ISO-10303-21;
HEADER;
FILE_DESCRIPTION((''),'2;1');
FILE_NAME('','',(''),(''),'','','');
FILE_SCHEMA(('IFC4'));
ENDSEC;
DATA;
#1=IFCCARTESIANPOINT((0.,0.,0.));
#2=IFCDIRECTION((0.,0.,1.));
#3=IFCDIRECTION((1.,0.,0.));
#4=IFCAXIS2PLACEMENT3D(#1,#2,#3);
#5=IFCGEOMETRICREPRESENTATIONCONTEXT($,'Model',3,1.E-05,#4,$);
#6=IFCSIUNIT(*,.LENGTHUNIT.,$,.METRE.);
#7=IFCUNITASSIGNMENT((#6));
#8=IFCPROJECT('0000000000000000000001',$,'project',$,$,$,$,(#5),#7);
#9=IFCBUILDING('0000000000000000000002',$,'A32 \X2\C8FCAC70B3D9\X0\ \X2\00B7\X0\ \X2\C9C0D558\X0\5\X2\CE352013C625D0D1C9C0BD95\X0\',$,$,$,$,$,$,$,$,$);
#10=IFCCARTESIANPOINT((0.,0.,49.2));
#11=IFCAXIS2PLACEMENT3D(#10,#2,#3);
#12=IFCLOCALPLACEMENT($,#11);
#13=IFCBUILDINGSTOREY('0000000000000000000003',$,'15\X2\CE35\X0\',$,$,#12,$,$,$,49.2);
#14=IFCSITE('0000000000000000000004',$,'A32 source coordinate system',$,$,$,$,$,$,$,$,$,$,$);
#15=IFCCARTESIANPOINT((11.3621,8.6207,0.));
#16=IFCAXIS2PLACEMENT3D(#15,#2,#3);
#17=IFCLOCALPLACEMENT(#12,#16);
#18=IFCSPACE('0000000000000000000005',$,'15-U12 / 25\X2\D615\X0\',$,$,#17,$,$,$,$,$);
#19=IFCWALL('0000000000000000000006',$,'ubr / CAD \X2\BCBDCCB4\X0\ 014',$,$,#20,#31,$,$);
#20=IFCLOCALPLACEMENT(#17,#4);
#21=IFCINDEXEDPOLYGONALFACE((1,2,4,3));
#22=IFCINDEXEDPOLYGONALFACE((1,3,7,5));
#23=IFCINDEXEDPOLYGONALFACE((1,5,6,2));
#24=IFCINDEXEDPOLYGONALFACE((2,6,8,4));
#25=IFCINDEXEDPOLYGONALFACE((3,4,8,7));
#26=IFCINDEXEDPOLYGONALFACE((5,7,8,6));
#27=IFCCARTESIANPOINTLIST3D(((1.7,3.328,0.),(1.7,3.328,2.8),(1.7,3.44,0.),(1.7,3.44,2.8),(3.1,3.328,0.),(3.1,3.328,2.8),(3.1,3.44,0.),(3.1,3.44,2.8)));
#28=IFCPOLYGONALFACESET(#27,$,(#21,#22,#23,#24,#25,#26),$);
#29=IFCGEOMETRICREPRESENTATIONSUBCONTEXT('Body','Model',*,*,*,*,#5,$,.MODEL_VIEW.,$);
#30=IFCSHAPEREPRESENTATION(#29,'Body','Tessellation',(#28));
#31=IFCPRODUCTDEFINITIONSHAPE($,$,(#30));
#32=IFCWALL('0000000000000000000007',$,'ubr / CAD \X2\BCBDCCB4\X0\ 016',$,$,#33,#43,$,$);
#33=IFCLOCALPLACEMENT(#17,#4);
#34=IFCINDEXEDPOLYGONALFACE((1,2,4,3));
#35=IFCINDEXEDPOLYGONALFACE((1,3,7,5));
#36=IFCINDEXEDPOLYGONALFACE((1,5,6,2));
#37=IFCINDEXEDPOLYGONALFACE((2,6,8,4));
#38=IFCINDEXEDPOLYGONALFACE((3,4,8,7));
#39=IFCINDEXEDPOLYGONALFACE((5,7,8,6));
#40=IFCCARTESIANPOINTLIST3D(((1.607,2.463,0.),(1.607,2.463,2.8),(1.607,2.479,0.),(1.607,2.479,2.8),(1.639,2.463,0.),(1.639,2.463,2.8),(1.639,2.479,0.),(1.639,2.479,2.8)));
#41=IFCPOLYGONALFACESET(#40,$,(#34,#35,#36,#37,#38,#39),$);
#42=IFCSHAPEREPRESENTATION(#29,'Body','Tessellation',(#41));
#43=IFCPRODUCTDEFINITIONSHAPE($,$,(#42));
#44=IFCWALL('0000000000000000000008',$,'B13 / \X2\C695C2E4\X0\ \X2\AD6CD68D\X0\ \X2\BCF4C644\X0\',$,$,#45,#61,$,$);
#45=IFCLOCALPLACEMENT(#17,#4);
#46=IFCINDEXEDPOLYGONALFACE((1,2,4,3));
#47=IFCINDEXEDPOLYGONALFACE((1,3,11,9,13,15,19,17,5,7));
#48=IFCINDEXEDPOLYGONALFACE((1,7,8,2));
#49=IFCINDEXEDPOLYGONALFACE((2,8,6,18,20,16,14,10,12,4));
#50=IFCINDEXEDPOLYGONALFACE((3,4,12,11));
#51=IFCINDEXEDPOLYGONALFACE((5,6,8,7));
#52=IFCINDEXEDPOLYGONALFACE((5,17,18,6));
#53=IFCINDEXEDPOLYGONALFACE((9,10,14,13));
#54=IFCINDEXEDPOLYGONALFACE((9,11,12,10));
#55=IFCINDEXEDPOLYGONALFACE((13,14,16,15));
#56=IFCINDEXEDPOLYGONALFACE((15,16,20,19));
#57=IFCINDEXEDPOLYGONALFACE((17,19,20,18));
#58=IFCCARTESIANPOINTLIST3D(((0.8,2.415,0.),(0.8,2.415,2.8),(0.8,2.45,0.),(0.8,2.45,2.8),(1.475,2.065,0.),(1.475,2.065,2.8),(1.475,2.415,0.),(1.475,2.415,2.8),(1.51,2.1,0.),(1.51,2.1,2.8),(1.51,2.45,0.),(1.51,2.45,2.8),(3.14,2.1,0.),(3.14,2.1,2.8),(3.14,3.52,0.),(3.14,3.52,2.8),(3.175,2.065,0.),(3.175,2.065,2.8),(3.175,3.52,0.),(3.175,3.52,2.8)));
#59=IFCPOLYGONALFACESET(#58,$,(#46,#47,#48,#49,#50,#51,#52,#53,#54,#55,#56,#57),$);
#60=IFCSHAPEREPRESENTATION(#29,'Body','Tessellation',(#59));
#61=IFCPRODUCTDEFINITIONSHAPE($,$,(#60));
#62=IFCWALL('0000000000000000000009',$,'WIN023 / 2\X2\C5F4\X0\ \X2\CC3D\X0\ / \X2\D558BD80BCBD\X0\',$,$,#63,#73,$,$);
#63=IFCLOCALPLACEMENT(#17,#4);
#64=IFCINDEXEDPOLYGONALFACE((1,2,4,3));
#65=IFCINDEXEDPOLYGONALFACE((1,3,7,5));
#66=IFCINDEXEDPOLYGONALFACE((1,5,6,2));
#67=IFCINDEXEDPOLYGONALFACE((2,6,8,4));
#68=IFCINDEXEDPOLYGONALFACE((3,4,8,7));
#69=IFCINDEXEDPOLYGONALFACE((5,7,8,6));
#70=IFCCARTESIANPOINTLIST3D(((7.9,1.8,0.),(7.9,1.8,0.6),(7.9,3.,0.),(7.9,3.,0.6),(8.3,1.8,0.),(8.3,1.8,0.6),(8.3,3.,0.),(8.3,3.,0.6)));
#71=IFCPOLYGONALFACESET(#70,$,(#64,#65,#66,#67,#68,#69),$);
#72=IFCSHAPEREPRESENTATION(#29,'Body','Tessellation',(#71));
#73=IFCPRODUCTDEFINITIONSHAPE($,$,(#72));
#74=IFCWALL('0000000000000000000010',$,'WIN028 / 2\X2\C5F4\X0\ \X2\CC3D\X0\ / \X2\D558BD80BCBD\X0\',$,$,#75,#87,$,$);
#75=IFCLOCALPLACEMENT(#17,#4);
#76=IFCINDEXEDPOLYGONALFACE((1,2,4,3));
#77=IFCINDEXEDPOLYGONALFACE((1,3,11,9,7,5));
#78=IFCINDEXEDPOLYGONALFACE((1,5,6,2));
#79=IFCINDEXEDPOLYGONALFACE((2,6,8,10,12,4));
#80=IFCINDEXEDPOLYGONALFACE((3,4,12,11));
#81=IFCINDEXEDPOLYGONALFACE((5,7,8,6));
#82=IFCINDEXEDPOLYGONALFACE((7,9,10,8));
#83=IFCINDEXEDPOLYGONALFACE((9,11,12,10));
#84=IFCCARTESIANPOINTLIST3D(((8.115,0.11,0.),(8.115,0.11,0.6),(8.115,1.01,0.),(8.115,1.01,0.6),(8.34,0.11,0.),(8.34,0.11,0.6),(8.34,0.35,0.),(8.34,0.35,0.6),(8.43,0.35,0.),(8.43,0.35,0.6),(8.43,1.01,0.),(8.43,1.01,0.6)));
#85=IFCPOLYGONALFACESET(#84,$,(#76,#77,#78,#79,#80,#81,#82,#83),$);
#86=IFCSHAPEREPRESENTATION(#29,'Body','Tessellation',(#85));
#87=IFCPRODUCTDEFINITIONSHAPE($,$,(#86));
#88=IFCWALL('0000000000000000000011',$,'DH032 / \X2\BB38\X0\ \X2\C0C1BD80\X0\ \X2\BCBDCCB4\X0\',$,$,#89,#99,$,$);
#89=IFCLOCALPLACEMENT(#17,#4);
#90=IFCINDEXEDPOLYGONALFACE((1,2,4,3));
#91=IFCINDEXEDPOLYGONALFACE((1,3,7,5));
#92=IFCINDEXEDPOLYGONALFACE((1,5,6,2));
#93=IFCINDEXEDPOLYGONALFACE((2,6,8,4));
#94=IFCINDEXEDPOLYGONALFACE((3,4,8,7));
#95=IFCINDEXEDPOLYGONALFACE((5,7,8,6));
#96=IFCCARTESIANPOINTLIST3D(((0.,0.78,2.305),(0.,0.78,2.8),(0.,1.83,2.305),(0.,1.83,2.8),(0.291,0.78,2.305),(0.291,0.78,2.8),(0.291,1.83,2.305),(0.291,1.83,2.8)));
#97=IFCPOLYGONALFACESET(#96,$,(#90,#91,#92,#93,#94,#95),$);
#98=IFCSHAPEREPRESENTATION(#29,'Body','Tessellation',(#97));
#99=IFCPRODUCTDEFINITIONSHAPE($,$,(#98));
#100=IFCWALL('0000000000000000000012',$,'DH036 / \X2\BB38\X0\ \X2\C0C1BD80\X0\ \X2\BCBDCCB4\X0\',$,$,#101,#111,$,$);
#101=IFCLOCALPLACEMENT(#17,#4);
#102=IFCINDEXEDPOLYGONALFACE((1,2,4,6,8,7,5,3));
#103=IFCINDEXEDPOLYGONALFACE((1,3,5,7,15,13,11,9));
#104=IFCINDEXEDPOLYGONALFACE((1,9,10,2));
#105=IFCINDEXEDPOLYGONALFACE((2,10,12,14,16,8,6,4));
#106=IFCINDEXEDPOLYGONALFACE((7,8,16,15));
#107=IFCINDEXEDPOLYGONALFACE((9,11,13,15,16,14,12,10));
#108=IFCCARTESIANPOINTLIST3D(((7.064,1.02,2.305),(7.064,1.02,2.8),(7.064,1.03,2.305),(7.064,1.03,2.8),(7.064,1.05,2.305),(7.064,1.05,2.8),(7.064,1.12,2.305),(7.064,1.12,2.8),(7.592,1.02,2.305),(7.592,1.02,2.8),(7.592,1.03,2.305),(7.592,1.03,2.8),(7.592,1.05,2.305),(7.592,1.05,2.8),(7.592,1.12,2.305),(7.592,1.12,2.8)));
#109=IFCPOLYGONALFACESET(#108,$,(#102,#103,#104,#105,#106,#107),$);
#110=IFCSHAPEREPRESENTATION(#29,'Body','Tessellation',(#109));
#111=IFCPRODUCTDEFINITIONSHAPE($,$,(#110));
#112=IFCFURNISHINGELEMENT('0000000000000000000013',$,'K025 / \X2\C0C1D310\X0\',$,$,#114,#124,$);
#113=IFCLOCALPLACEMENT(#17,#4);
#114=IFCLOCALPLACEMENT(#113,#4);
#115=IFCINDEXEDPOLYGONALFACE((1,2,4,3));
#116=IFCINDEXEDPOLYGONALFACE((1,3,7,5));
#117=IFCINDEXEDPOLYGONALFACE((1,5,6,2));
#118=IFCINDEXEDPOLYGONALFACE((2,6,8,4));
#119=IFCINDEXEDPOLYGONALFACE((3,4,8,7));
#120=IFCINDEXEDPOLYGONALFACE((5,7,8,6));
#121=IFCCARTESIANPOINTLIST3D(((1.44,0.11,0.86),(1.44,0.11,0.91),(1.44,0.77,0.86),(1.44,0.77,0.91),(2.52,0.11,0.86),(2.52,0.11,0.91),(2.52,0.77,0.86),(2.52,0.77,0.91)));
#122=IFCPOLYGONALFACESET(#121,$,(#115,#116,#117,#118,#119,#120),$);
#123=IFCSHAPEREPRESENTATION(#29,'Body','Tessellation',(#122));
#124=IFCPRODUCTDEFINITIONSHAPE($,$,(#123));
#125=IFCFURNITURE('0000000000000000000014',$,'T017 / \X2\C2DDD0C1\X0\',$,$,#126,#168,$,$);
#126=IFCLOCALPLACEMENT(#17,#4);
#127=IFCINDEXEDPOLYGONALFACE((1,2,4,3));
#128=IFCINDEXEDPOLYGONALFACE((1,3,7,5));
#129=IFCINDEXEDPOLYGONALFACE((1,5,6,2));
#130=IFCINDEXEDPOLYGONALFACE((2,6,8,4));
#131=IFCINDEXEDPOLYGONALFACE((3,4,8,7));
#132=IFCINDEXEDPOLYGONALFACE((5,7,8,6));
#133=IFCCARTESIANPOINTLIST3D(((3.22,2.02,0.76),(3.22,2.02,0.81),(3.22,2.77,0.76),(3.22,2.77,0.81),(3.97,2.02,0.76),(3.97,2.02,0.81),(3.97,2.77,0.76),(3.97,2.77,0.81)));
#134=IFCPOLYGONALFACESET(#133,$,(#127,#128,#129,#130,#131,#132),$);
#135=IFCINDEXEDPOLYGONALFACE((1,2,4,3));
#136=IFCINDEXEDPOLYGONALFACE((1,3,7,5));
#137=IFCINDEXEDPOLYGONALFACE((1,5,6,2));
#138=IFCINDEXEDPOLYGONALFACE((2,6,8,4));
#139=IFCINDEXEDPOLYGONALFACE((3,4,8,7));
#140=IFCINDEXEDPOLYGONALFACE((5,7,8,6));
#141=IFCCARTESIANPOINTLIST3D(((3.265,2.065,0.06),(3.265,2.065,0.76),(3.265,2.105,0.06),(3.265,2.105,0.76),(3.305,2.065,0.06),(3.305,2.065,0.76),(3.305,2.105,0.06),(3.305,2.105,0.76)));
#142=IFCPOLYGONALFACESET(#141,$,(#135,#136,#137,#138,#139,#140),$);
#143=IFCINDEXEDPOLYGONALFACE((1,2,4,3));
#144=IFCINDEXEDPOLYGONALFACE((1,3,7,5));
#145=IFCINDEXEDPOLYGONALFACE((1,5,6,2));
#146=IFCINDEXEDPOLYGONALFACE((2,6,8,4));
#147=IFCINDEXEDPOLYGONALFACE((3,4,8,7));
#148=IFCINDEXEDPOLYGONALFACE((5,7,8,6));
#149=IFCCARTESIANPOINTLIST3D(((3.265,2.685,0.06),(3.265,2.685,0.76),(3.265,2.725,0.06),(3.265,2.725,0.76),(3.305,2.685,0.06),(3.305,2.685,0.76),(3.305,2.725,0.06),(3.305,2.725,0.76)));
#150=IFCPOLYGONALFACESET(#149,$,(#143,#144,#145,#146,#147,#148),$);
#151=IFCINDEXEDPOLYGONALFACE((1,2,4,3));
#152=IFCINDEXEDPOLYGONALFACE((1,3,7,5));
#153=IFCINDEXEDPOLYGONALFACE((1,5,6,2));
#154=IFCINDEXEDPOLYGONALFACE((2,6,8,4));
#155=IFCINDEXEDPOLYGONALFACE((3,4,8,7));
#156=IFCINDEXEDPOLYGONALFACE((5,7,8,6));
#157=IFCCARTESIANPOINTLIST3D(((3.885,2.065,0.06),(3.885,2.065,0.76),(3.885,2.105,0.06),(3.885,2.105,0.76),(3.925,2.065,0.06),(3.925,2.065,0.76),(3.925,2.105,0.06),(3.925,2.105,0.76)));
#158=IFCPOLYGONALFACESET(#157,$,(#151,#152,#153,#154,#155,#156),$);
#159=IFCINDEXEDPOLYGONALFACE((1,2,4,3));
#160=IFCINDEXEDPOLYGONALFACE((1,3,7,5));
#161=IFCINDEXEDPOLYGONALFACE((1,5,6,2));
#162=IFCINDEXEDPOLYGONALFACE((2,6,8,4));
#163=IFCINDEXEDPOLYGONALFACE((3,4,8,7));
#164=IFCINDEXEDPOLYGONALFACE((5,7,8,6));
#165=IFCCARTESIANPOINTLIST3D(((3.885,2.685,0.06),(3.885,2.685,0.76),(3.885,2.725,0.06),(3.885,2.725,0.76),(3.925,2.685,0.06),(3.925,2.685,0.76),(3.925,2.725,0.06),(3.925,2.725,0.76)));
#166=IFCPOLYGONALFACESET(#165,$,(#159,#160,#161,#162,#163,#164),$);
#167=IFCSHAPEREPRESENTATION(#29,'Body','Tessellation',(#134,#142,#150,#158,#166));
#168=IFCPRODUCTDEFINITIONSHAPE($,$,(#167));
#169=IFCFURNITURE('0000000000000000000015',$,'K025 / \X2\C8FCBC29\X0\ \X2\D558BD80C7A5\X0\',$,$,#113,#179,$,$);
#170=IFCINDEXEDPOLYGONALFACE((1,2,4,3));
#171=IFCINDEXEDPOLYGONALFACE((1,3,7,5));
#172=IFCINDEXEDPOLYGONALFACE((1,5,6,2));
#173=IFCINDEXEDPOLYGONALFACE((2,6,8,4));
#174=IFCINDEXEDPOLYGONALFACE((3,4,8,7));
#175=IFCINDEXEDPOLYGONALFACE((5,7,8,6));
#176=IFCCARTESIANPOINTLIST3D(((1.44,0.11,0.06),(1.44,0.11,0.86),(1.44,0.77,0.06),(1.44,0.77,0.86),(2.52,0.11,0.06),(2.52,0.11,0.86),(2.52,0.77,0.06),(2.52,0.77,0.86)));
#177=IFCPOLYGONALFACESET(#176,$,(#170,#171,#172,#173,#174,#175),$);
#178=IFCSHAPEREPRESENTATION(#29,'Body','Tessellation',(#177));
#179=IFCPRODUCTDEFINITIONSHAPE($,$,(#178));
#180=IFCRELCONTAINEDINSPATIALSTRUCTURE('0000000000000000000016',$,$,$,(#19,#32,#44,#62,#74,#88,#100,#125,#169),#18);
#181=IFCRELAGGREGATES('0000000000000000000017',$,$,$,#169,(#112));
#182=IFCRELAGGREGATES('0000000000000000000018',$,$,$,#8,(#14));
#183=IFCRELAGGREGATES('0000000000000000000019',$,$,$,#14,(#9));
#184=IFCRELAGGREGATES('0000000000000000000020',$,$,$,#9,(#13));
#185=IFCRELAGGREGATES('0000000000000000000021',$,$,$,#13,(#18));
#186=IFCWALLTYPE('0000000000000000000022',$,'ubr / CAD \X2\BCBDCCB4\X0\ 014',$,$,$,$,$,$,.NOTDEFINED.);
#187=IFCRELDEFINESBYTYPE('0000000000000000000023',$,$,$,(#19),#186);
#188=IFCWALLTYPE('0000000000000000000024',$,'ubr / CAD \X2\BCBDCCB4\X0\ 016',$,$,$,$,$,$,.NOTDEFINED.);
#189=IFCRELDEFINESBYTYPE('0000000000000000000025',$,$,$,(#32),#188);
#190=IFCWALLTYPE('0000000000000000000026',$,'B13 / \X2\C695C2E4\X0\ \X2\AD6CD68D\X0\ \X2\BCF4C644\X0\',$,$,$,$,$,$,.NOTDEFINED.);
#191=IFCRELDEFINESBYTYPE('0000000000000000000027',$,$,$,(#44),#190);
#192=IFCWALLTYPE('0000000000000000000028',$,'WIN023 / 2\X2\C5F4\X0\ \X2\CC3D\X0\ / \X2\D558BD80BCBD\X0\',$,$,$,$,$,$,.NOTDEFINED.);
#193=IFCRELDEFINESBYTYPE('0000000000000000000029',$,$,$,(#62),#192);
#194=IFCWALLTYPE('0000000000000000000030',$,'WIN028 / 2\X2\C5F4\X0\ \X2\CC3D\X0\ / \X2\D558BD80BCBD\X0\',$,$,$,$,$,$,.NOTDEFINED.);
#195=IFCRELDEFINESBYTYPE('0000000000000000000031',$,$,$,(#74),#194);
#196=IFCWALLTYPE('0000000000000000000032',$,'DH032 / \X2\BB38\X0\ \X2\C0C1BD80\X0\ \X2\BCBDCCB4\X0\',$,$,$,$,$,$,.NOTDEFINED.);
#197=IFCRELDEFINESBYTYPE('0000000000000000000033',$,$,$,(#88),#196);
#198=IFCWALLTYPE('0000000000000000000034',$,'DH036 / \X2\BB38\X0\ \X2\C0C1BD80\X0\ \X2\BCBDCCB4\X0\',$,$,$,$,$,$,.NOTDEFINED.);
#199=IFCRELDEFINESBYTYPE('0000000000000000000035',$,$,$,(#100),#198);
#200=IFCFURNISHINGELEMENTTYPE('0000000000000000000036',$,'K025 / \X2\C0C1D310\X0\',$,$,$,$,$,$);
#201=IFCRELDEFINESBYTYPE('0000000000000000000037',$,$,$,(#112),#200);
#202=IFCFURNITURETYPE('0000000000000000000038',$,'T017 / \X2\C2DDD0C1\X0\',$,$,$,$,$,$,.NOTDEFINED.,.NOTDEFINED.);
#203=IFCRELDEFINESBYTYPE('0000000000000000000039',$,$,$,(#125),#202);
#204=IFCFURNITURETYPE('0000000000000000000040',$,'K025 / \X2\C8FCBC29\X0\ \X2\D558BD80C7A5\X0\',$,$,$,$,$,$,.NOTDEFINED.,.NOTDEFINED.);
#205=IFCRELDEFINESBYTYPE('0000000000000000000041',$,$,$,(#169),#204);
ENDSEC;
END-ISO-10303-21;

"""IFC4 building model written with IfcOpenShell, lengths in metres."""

from ifc_helpers import new_model, si_unit, frame, origin, origin_with_axes, place, context, subcontext, project, spatial, polyline, outline, extrude, source, transform, mapped, type_object, type_shapes, element, aggregate, save


model = new_model("IFC4")

# Units and contexts
model_context = context("Model", 3, precision=1e-05, world=origin_with_axes())
body_context = subcontext(model_context, "Body", "Model", "MODEL_VIEW")
ifc_project = project(units=[si_unit("LENGTHUNIT", "METRE")], contexts=[model_context])

# Site, building, storey, space
site = spatial("IfcSite", under=ifc_project, Name="A32 source coordinate system")
building = spatial("IfcBuilding", under=site, Name="A32 주거동 · 지하5층–옥탑지붕")
storey_placement = place(None, frame((0.0, 0.0, 49.2), z_axis=(0.0, 0.0, 1.0), x_axis=(1.0, 0.0, 0.0)))
storey = spatial("IfcBuildingStorey", under=building, at=storey_placement, Name="15층", Elevation=49.2)
space_1_placement = place(storey_placement, frame((11.3621, 8.6207, 0.0), z_axis=(0.0, 0.0, 1.0), x_axis=(1.0, 0.0, 0.0)))
space_1 = spatial("IfcSpace", under=storey, at=space_1_placement, Name="15-U12 / 25형")

# Walls
wall_type_1 = type_object("IfcWallType", Name="ubr / CAD 벽체 014", PredefinedType="NOTDEFINED")
shared_shape_1 = source(origin(), body_context, "Body", "SweptSolid", [
    extrude(outline(polyline([(3.1, 3.44), (3.1, 3.328), (1.7, 3.328), (1.7, 3.44), (3.1, 3.44)])), origin(), (0.0, 0.0, 1.0), 2.8),
])
type_shapes(wall_type_1, [shared_shape_1])
wall_1_placement = place(space_1_placement, origin_with_axes())
element("IfcWall", 1, at=wall_1_placement, inside=space_1, type_object=wall_type_1, Name="ubr / CAD 벽체 014", context=body_context, shape_type="MappedRepresentation", body=[
    mapped(shared_shape_1, transform((0.0, 0.0, 0.0), scale=1.0)),
])
wall_type_2 = type_object("IfcWallType", Name="ubr / CAD 벽체 016", PredefinedType="NOTDEFINED")
shared_shape_2 = source(origin(), body_context, "Body", "SweptSolid", [
    extrude(outline(polyline([(1.639, 2.479), (1.639, 2.463), (1.607, 2.463), (1.607, 2.479), (1.639, 2.479)])), origin(), (0.0, 0.0, 1.0), 2.8),
])
type_shapes(wall_type_2, [shared_shape_2])
wall_2_placement = place(space_1_placement, origin_with_axes())
element("IfcWall", 2, at=wall_2_placement, inside=space_1, type_object=wall_type_2, Name="ubr / CAD 벽체 016", context=body_context, shape_type="MappedRepresentation", body=[
    mapped(shared_shape_2, transform((0.0, 0.0, 0.0), scale=1.0)),
])
wall_type_3 = type_object("IfcWallType", Name="B13 / 욕실 구획 보완", PredefinedType="NOTDEFINED")
shared_shape_3 = source(origin(), body_context, "Body", "SweptSolid", [
    extrude(outline(polyline([(0.8, 2.45), (1.51, 2.45), (1.51, 2.1), (3.14, 2.1), (3.14, 3.52), (3.175, 3.52), (3.175, 2.065), (1.475, 2.065), (1.475, 2.415), (0.8, 2.415), (0.8, 2.45)])), origin(), (0.0, 0.0, 1.0), 2.8),
])
type_shapes(wall_type_3, [shared_shape_3])
wall_3_placement = place(space_1_placement, origin_with_axes())
element("IfcWall", 3, at=wall_3_placement, inside=space_1, type_object=wall_type_3, Name="B13 / 욕실 구획 보완", context=body_context, shape_type="MappedRepresentation", body=[
    mapped(shared_shape_3, transform((0.0, 0.0, 0.0), scale=1.0)),
])
wall_type_4 = type_object("IfcWallType", Name="WIN023 / 2열 창 / 하부벽", PredefinedType="NOTDEFINED")
shared_shape_4 = source(origin(), body_context, "Body", "SweptSolid", [
    extrude(outline(polyline([(7.9, 1.8), (7.9, 3.0), (8.3, 3.0), (8.3, 1.8), (7.9, 1.8)])), origin(), (0.0, 0.0, 1.0), 0.6),
])
type_shapes(wall_type_4, [shared_shape_4])
wall_4_placement = place(space_1_placement, origin_with_axes())
element("IfcWall", 4, at=wall_4_placement, inside=space_1, type_object=wall_type_4, Name="WIN023 / 2열 창 / 하부벽", context=body_context, shape_type="MappedRepresentation", body=[
    mapped(shared_shape_4, transform((0.0, 0.0, 0.0), scale=1.0)),
])
wall_type_5 = type_object("IfcWallType", Name="WIN028 / 2열 창 / 하부벽", PredefinedType="NOTDEFINED")
shared_shape_5 = source(origin(), body_context, "Body", "SweptSolid", [
    extrude(outline(polyline([(8.34, 0.35), (8.34, 0.11), (8.115, 0.11), (8.115, 1.01), (8.43, 1.01), (8.43, 0.35), (8.34, 0.35)])), origin(), (0.0, 0.0, 1.0), 0.6),
])
type_shapes(wall_type_5, [shared_shape_5])
wall_5_placement = place(space_1_placement, origin_with_axes())
element("IfcWall", 5, at=wall_5_placement, inside=space_1, type_object=wall_type_5, Name="WIN028 / 2열 창 / 하부벽", context=body_context, shape_type="MappedRepresentation", body=[
    mapped(shared_shape_5, transform((0.0, 0.0, 0.0), scale=1.0)),
])
wall_type_6 = type_object("IfcWallType", Name="DH032 / 문 상부 벽체", PredefinedType="NOTDEFINED")
shared_shape_6 = source(origin(), body_context, "Body", "SweptSolid", [
    extrude(outline(polyline([(0.0, 1.83), (0.291, 1.83), (0.291, 0.78), (0.0, 0.78), (0.0, 1.83)])), frame((0.0, 0.0, 2.305)), (0.0, 0.0, 1.0), 0.495),
])
type_shapes(wall_type_6, [shared_shape_6])
wall_6_placement = place(space_1_placement, origin_with_axes())
element("IfcWall", 6, at=wall_6_placement, inside=space_1, type_object=wall_type_6, Name="DH032 / 문 상부 벽체", context=body_context, shape_type="MappedRepresentation", body=[
    mapped(shared_shape_6, transform((0.0, 0.0, 0.0), scale=1.0)),
])
wall_type_7 = type_object("IfcWallType", Name="DH036 / 문 상부 벽체", PredefinedType="NOTDEFINED")
shared_shape_7 = source(origin(), body_context, "Body", "SweptSolid", [
    extrude(outline(polyline([(7.064, 1.03), (7.064, 1.05), (7.064, 1.12), (7.592, 1.12), (7.592, 1.05), (7.592, 1.03), (7.592, 1.02), (7.064, 1.02), (7.064, 1.03)])), frame((0.0, 0.0, 2.305)), (0.0, 0.0, 1.0), 0.495),
])
type_shapes(wall_type_7, [shared_shape_7])
wall_7_placement = place(space_1_placement, origin_with_axes())
element("IfcWall", 7, at=wall_7_placement, inside=space_1, type_object=wall_type_7, Name="DH036 / 문 상부 벽체", context=body_context, shape_type="MappedRepresentation", body=[
    mapped(shared_shape_7, transform((0.0, 0.0, 0.0), scale=1.0)),
])

# Furnishing element
furnishing_element_type_1 = type_object("IfcFurnishingElementType", Name="K025 / 상판")
shared_shape_8 = source(origin(), body_context, "Body", "SweptSolid", [
    extrude(outline(polyline([(2.52, 0.77), (2.52, 0.11), (1.44, 0.11), (1.44, 0.77), (2.52, 0.77)])), frame((0.0, 0.0, 0.86)), (0.0, 0.0, 1.0), 0.05),
])
type_shapes(furnishing_element_type_1, [shared_shape_8])
furniture_1_placement = place(space_1_placement, origin_with_axes())
furnishing_1_placement = place(furniture_1_placement, origin_with_axes())
furnishing_1 = element("IfcFurnishingElement", 8, at=furnishing_1_placement, type_object=furnishing_element_type_1, Name="K025 / 상판", context=body_context, shape_type="MappedRepresentation", body=[
    mapped(shared_shape_8, transform((0.0, 0.0, 0.0), scale=1.0)),
])

# Furniture
furniture_type_1 = type_object("IfcFurnitureType", Name="T017 / 식탁", AssemblyPlace="NOTDEFINED", PredefinedType="NOTDEFINED")
shared_shape_9 = source(origin(), body_context, "Body", "SweptSolid", [
    extrude(outline(polyline([(3.97, 2.02), (3.22, 2.02), (3.22, 2.77), (3.97, 2.77), (3.97, 2.02)])), frame((0.0, 0.0, 0.76)), (0.0, 0.0, 1.0), 0.05),
    extrude(outline(polyline([(3.265, 2.065), (3.265, 2.105), (3.305, 2.105), (3.305, 2.065), (3.265, 2.065)])), frame((0.0, 0.0, 0.06)), (0.0, 0.0, 1.0), 0.7),
    extrude(outline(polyline([(3.265, 2.685), (3.265, 2.725), (3.305, 2.725), (3.305, 2.685), (3.265, 2.685)])), frame((0.0, 0.0, 0.06)), (0.0, 0.0, 1.0), 0.7),
    extrude(outline(polyline([(3.885, 2.065), (3.885, 2.105), (3.925, 2.105), (3.925, 2.065), (3.885, 2.065)])), frame((0.0, 0.0, 0.06)), (0.0, 0.0, 1.0), 0.7),
    extrude(outline(polyline([(3.885, 2.685), (3.885, 2.725), (3.925, 2.725), (3.925, 2.685), (3.885, 2.685)])), frame((0.0, 0.0, 0.06)), (0.0, 0.0, 1.0), 0.7),
])
type_shapes(furniture_type_1, [shared_shape_9])
furniture_2_placement = place(space_1_placement, origin_with_axes())
element("IfcFurniture", 9, at=furniture_2_placement, inside=space_1, type_object=furniture_type_1, Name="T017 / 식탁", context=body_context, shape_type="MappedRepresentation", body=[
    mapped(shared_shape_9, transform((0.0, 0.0, 0.0), scale=1.0)),
])
furniture_type_2 = type_object("IfcFurnitureType", Name="K025 / 주방 하부장", AssemblyPlace="NOTDEFINED", PredefinedType="NOTDEFINED")
shared_shape_10 = source(origin(), body_context, "Body", "SweptSolid", [
    extrude(outline(polyline([(1.44, 0.77), (2.52, 0.77), (2.52, 0.11), (1.44, 0.11), (1.44, 0.77)])), frame((0.0, 0.0, 0.06)), (0.0, 0.0, 1.0), 0.8),
])
type_shapes(furniture_type_2, [shared_shape_10])
furniture_1 = element("IfcFurniture", 10, at=furniture_1_placement, inside=space_1, type_object=furniture_type_2, Name="K025 / 주방 하부장", context=body_context, shape_type="MappedRepresentation", body=[
    mapped(shared_shape_10, transform((0.0, 0.0, 0.0), scale=1.0)),
])
aggregate(furniture_1, [furnishing_1])

save(model, "model.ifc")
